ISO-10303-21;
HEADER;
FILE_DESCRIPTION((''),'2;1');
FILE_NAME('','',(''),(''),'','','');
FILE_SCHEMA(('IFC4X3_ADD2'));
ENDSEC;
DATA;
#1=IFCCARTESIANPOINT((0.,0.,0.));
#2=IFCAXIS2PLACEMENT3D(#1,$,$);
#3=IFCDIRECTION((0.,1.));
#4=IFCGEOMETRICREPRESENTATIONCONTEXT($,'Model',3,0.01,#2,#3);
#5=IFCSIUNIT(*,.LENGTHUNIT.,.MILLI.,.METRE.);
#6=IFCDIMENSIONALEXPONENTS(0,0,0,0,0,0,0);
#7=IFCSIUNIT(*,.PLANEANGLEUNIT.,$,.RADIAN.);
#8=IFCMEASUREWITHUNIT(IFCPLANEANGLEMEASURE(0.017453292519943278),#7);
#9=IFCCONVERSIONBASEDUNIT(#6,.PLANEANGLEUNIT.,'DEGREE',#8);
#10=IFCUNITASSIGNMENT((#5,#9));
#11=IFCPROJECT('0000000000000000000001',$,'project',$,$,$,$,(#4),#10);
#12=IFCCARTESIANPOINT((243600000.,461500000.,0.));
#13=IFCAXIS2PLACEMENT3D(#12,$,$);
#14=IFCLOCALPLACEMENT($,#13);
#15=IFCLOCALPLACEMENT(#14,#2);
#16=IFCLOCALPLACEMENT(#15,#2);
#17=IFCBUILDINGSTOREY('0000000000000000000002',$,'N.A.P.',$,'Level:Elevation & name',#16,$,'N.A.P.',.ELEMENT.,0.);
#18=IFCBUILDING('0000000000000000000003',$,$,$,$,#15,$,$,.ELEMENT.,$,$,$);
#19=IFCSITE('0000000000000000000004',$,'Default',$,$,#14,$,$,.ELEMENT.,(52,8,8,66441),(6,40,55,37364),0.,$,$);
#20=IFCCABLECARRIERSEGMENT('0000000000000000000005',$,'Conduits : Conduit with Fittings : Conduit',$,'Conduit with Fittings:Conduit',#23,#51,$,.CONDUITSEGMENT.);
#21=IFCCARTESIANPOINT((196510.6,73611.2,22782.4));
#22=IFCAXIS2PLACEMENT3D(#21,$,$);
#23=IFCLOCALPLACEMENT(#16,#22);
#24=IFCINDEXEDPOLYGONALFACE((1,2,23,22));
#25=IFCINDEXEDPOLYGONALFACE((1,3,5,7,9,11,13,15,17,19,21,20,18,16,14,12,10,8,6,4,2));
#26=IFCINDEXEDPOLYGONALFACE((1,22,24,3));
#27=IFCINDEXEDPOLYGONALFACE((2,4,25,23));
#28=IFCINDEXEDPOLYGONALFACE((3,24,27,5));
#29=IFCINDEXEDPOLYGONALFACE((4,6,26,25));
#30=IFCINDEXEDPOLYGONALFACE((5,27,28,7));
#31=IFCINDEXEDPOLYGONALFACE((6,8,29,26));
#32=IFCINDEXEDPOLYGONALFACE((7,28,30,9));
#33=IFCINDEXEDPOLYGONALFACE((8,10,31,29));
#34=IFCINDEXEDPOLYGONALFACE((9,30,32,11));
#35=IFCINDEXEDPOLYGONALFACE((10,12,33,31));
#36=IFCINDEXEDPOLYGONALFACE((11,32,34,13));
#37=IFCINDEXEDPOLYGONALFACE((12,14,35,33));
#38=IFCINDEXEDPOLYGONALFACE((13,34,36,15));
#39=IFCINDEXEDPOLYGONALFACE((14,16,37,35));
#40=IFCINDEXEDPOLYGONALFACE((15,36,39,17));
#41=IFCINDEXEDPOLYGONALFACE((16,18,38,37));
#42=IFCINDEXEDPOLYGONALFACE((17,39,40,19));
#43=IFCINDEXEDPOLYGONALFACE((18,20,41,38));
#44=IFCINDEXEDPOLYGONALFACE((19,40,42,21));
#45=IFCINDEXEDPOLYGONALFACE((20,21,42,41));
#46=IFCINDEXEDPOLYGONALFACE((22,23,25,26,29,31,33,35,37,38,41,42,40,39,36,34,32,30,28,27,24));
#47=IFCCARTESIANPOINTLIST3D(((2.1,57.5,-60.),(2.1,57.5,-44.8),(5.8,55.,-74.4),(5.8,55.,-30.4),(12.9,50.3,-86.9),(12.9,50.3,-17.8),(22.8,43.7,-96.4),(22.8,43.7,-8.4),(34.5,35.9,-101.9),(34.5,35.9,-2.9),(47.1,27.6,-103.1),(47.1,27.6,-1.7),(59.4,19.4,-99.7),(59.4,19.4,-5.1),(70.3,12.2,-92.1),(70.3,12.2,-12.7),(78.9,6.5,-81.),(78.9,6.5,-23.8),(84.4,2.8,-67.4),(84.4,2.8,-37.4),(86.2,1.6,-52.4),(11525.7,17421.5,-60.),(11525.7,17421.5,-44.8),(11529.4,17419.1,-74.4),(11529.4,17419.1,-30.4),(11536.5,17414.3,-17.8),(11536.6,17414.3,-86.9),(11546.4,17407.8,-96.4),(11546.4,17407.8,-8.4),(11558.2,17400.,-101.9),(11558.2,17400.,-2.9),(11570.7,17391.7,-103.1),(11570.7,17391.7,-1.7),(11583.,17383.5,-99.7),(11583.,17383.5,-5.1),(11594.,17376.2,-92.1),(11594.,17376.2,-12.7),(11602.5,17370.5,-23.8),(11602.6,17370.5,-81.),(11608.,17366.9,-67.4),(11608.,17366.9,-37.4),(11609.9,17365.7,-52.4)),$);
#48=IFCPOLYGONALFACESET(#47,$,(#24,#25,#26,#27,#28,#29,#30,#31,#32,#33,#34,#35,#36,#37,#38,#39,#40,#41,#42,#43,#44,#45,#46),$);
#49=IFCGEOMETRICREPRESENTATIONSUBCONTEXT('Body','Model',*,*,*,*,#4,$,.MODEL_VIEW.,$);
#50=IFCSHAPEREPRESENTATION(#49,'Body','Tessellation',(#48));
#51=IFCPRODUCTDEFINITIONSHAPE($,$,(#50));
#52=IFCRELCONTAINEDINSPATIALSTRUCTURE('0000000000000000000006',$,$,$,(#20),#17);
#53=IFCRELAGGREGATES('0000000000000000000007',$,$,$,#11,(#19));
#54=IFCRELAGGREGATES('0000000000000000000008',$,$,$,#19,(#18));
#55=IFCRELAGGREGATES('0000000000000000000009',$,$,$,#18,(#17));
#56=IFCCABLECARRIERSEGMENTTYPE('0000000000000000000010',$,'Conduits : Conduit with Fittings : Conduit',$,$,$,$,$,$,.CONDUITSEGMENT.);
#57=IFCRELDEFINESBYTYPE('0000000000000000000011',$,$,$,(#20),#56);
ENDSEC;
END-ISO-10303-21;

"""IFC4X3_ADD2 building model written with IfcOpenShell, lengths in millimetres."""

from ifc_helpers import new_model, entity, si_unit, converted_unit, direction, frame, frame_2d, origin, place, context, subcontext, project, spatial, circle, extrude, type_object, element, save


model = new_model("IFC4X3_ADD2")

# Units and contexts
model_context = context("Model", 3, precision=0.01, world=origin(), true_north=direction((0.0, 1.0)))
body_context = subcontext(model_context, "Body", "Model", "MODEL_VIEW")
ifc_project = project(units=[si_unit("LENGTHUNIT", "METRE", prefix="MILLI"), converted_unit("PLANEANGLEUNIT", "DEGREE", entity("IfcPlaneAngleMeasure", 0.017453292519943278), si_unit("PLANEANGLEUNIT", "RADIAN"), dimensions=[0, 0, 0, 0, 0, 0, 0])], contexts=[model_context])

# Site, building, storey
site_placement = place(None, frame((243600000.0, 461500000.0, 0.0)))
site = spatial("IfcSite", under=ifc_project, at=site_placement, Name="Default", CompositionType="ELEMENT", RefLatitude=(52, 8, 8, 66441), RefLongitude=(6, 40, 55, 37364), RefElevation=0.0)
building_placement = place(site_placement, origin())
building = spatial("IfcBuilding", under=site, at=building_placement, CompositionType="ELEMENT")
storey_placement = place(building_placement, origin())
storey = spatial("IfcBuildingStorey", under=building, at=storey_placement, Name="N.A.P.", ObjectType="Level:Elevation & name", LongName="N.A.P.", CompositionType="ELEMENT", Elevation=0.0)

# Cable carrier segment
cable_carrier_segment_type = type_object("IfcCableCarrierSegmentType", Name="Conduits : Conduit with Fittings : Conduit", PredefinedType="CONDUITSEGMENT")
cable_carrier_segment_1_placement = place(storey_placement, frame((196510.6, 73611.2, 22782.4)))
element("IfcCableCarrierSegment", 1, at=cable_carrier_segment_1_placement, inside=storey, type_object=cable_carrier_segment_type, Name="Conduits : Conduit with Fittings : Conduit", ObjectType="Conduit with Fittings:Conduit", PredefinedType="CONDUITSEGMENT", context=body_context, shape_type="SweptSolid", body=[
    extrude(circle(Radius=50.8, at=frame_2d((0.0, 0.0), x_axis=(1.0, 0.0))), frame((43.9, 29.7, -52.4), z_axis=(0.552959, 0.833209, 0.0), x_axis=(0.833209, -0.552959, 0.000005)), (0.0, 0.0, 1.0), 20840.0),
])

save(model, "model.ifc")
